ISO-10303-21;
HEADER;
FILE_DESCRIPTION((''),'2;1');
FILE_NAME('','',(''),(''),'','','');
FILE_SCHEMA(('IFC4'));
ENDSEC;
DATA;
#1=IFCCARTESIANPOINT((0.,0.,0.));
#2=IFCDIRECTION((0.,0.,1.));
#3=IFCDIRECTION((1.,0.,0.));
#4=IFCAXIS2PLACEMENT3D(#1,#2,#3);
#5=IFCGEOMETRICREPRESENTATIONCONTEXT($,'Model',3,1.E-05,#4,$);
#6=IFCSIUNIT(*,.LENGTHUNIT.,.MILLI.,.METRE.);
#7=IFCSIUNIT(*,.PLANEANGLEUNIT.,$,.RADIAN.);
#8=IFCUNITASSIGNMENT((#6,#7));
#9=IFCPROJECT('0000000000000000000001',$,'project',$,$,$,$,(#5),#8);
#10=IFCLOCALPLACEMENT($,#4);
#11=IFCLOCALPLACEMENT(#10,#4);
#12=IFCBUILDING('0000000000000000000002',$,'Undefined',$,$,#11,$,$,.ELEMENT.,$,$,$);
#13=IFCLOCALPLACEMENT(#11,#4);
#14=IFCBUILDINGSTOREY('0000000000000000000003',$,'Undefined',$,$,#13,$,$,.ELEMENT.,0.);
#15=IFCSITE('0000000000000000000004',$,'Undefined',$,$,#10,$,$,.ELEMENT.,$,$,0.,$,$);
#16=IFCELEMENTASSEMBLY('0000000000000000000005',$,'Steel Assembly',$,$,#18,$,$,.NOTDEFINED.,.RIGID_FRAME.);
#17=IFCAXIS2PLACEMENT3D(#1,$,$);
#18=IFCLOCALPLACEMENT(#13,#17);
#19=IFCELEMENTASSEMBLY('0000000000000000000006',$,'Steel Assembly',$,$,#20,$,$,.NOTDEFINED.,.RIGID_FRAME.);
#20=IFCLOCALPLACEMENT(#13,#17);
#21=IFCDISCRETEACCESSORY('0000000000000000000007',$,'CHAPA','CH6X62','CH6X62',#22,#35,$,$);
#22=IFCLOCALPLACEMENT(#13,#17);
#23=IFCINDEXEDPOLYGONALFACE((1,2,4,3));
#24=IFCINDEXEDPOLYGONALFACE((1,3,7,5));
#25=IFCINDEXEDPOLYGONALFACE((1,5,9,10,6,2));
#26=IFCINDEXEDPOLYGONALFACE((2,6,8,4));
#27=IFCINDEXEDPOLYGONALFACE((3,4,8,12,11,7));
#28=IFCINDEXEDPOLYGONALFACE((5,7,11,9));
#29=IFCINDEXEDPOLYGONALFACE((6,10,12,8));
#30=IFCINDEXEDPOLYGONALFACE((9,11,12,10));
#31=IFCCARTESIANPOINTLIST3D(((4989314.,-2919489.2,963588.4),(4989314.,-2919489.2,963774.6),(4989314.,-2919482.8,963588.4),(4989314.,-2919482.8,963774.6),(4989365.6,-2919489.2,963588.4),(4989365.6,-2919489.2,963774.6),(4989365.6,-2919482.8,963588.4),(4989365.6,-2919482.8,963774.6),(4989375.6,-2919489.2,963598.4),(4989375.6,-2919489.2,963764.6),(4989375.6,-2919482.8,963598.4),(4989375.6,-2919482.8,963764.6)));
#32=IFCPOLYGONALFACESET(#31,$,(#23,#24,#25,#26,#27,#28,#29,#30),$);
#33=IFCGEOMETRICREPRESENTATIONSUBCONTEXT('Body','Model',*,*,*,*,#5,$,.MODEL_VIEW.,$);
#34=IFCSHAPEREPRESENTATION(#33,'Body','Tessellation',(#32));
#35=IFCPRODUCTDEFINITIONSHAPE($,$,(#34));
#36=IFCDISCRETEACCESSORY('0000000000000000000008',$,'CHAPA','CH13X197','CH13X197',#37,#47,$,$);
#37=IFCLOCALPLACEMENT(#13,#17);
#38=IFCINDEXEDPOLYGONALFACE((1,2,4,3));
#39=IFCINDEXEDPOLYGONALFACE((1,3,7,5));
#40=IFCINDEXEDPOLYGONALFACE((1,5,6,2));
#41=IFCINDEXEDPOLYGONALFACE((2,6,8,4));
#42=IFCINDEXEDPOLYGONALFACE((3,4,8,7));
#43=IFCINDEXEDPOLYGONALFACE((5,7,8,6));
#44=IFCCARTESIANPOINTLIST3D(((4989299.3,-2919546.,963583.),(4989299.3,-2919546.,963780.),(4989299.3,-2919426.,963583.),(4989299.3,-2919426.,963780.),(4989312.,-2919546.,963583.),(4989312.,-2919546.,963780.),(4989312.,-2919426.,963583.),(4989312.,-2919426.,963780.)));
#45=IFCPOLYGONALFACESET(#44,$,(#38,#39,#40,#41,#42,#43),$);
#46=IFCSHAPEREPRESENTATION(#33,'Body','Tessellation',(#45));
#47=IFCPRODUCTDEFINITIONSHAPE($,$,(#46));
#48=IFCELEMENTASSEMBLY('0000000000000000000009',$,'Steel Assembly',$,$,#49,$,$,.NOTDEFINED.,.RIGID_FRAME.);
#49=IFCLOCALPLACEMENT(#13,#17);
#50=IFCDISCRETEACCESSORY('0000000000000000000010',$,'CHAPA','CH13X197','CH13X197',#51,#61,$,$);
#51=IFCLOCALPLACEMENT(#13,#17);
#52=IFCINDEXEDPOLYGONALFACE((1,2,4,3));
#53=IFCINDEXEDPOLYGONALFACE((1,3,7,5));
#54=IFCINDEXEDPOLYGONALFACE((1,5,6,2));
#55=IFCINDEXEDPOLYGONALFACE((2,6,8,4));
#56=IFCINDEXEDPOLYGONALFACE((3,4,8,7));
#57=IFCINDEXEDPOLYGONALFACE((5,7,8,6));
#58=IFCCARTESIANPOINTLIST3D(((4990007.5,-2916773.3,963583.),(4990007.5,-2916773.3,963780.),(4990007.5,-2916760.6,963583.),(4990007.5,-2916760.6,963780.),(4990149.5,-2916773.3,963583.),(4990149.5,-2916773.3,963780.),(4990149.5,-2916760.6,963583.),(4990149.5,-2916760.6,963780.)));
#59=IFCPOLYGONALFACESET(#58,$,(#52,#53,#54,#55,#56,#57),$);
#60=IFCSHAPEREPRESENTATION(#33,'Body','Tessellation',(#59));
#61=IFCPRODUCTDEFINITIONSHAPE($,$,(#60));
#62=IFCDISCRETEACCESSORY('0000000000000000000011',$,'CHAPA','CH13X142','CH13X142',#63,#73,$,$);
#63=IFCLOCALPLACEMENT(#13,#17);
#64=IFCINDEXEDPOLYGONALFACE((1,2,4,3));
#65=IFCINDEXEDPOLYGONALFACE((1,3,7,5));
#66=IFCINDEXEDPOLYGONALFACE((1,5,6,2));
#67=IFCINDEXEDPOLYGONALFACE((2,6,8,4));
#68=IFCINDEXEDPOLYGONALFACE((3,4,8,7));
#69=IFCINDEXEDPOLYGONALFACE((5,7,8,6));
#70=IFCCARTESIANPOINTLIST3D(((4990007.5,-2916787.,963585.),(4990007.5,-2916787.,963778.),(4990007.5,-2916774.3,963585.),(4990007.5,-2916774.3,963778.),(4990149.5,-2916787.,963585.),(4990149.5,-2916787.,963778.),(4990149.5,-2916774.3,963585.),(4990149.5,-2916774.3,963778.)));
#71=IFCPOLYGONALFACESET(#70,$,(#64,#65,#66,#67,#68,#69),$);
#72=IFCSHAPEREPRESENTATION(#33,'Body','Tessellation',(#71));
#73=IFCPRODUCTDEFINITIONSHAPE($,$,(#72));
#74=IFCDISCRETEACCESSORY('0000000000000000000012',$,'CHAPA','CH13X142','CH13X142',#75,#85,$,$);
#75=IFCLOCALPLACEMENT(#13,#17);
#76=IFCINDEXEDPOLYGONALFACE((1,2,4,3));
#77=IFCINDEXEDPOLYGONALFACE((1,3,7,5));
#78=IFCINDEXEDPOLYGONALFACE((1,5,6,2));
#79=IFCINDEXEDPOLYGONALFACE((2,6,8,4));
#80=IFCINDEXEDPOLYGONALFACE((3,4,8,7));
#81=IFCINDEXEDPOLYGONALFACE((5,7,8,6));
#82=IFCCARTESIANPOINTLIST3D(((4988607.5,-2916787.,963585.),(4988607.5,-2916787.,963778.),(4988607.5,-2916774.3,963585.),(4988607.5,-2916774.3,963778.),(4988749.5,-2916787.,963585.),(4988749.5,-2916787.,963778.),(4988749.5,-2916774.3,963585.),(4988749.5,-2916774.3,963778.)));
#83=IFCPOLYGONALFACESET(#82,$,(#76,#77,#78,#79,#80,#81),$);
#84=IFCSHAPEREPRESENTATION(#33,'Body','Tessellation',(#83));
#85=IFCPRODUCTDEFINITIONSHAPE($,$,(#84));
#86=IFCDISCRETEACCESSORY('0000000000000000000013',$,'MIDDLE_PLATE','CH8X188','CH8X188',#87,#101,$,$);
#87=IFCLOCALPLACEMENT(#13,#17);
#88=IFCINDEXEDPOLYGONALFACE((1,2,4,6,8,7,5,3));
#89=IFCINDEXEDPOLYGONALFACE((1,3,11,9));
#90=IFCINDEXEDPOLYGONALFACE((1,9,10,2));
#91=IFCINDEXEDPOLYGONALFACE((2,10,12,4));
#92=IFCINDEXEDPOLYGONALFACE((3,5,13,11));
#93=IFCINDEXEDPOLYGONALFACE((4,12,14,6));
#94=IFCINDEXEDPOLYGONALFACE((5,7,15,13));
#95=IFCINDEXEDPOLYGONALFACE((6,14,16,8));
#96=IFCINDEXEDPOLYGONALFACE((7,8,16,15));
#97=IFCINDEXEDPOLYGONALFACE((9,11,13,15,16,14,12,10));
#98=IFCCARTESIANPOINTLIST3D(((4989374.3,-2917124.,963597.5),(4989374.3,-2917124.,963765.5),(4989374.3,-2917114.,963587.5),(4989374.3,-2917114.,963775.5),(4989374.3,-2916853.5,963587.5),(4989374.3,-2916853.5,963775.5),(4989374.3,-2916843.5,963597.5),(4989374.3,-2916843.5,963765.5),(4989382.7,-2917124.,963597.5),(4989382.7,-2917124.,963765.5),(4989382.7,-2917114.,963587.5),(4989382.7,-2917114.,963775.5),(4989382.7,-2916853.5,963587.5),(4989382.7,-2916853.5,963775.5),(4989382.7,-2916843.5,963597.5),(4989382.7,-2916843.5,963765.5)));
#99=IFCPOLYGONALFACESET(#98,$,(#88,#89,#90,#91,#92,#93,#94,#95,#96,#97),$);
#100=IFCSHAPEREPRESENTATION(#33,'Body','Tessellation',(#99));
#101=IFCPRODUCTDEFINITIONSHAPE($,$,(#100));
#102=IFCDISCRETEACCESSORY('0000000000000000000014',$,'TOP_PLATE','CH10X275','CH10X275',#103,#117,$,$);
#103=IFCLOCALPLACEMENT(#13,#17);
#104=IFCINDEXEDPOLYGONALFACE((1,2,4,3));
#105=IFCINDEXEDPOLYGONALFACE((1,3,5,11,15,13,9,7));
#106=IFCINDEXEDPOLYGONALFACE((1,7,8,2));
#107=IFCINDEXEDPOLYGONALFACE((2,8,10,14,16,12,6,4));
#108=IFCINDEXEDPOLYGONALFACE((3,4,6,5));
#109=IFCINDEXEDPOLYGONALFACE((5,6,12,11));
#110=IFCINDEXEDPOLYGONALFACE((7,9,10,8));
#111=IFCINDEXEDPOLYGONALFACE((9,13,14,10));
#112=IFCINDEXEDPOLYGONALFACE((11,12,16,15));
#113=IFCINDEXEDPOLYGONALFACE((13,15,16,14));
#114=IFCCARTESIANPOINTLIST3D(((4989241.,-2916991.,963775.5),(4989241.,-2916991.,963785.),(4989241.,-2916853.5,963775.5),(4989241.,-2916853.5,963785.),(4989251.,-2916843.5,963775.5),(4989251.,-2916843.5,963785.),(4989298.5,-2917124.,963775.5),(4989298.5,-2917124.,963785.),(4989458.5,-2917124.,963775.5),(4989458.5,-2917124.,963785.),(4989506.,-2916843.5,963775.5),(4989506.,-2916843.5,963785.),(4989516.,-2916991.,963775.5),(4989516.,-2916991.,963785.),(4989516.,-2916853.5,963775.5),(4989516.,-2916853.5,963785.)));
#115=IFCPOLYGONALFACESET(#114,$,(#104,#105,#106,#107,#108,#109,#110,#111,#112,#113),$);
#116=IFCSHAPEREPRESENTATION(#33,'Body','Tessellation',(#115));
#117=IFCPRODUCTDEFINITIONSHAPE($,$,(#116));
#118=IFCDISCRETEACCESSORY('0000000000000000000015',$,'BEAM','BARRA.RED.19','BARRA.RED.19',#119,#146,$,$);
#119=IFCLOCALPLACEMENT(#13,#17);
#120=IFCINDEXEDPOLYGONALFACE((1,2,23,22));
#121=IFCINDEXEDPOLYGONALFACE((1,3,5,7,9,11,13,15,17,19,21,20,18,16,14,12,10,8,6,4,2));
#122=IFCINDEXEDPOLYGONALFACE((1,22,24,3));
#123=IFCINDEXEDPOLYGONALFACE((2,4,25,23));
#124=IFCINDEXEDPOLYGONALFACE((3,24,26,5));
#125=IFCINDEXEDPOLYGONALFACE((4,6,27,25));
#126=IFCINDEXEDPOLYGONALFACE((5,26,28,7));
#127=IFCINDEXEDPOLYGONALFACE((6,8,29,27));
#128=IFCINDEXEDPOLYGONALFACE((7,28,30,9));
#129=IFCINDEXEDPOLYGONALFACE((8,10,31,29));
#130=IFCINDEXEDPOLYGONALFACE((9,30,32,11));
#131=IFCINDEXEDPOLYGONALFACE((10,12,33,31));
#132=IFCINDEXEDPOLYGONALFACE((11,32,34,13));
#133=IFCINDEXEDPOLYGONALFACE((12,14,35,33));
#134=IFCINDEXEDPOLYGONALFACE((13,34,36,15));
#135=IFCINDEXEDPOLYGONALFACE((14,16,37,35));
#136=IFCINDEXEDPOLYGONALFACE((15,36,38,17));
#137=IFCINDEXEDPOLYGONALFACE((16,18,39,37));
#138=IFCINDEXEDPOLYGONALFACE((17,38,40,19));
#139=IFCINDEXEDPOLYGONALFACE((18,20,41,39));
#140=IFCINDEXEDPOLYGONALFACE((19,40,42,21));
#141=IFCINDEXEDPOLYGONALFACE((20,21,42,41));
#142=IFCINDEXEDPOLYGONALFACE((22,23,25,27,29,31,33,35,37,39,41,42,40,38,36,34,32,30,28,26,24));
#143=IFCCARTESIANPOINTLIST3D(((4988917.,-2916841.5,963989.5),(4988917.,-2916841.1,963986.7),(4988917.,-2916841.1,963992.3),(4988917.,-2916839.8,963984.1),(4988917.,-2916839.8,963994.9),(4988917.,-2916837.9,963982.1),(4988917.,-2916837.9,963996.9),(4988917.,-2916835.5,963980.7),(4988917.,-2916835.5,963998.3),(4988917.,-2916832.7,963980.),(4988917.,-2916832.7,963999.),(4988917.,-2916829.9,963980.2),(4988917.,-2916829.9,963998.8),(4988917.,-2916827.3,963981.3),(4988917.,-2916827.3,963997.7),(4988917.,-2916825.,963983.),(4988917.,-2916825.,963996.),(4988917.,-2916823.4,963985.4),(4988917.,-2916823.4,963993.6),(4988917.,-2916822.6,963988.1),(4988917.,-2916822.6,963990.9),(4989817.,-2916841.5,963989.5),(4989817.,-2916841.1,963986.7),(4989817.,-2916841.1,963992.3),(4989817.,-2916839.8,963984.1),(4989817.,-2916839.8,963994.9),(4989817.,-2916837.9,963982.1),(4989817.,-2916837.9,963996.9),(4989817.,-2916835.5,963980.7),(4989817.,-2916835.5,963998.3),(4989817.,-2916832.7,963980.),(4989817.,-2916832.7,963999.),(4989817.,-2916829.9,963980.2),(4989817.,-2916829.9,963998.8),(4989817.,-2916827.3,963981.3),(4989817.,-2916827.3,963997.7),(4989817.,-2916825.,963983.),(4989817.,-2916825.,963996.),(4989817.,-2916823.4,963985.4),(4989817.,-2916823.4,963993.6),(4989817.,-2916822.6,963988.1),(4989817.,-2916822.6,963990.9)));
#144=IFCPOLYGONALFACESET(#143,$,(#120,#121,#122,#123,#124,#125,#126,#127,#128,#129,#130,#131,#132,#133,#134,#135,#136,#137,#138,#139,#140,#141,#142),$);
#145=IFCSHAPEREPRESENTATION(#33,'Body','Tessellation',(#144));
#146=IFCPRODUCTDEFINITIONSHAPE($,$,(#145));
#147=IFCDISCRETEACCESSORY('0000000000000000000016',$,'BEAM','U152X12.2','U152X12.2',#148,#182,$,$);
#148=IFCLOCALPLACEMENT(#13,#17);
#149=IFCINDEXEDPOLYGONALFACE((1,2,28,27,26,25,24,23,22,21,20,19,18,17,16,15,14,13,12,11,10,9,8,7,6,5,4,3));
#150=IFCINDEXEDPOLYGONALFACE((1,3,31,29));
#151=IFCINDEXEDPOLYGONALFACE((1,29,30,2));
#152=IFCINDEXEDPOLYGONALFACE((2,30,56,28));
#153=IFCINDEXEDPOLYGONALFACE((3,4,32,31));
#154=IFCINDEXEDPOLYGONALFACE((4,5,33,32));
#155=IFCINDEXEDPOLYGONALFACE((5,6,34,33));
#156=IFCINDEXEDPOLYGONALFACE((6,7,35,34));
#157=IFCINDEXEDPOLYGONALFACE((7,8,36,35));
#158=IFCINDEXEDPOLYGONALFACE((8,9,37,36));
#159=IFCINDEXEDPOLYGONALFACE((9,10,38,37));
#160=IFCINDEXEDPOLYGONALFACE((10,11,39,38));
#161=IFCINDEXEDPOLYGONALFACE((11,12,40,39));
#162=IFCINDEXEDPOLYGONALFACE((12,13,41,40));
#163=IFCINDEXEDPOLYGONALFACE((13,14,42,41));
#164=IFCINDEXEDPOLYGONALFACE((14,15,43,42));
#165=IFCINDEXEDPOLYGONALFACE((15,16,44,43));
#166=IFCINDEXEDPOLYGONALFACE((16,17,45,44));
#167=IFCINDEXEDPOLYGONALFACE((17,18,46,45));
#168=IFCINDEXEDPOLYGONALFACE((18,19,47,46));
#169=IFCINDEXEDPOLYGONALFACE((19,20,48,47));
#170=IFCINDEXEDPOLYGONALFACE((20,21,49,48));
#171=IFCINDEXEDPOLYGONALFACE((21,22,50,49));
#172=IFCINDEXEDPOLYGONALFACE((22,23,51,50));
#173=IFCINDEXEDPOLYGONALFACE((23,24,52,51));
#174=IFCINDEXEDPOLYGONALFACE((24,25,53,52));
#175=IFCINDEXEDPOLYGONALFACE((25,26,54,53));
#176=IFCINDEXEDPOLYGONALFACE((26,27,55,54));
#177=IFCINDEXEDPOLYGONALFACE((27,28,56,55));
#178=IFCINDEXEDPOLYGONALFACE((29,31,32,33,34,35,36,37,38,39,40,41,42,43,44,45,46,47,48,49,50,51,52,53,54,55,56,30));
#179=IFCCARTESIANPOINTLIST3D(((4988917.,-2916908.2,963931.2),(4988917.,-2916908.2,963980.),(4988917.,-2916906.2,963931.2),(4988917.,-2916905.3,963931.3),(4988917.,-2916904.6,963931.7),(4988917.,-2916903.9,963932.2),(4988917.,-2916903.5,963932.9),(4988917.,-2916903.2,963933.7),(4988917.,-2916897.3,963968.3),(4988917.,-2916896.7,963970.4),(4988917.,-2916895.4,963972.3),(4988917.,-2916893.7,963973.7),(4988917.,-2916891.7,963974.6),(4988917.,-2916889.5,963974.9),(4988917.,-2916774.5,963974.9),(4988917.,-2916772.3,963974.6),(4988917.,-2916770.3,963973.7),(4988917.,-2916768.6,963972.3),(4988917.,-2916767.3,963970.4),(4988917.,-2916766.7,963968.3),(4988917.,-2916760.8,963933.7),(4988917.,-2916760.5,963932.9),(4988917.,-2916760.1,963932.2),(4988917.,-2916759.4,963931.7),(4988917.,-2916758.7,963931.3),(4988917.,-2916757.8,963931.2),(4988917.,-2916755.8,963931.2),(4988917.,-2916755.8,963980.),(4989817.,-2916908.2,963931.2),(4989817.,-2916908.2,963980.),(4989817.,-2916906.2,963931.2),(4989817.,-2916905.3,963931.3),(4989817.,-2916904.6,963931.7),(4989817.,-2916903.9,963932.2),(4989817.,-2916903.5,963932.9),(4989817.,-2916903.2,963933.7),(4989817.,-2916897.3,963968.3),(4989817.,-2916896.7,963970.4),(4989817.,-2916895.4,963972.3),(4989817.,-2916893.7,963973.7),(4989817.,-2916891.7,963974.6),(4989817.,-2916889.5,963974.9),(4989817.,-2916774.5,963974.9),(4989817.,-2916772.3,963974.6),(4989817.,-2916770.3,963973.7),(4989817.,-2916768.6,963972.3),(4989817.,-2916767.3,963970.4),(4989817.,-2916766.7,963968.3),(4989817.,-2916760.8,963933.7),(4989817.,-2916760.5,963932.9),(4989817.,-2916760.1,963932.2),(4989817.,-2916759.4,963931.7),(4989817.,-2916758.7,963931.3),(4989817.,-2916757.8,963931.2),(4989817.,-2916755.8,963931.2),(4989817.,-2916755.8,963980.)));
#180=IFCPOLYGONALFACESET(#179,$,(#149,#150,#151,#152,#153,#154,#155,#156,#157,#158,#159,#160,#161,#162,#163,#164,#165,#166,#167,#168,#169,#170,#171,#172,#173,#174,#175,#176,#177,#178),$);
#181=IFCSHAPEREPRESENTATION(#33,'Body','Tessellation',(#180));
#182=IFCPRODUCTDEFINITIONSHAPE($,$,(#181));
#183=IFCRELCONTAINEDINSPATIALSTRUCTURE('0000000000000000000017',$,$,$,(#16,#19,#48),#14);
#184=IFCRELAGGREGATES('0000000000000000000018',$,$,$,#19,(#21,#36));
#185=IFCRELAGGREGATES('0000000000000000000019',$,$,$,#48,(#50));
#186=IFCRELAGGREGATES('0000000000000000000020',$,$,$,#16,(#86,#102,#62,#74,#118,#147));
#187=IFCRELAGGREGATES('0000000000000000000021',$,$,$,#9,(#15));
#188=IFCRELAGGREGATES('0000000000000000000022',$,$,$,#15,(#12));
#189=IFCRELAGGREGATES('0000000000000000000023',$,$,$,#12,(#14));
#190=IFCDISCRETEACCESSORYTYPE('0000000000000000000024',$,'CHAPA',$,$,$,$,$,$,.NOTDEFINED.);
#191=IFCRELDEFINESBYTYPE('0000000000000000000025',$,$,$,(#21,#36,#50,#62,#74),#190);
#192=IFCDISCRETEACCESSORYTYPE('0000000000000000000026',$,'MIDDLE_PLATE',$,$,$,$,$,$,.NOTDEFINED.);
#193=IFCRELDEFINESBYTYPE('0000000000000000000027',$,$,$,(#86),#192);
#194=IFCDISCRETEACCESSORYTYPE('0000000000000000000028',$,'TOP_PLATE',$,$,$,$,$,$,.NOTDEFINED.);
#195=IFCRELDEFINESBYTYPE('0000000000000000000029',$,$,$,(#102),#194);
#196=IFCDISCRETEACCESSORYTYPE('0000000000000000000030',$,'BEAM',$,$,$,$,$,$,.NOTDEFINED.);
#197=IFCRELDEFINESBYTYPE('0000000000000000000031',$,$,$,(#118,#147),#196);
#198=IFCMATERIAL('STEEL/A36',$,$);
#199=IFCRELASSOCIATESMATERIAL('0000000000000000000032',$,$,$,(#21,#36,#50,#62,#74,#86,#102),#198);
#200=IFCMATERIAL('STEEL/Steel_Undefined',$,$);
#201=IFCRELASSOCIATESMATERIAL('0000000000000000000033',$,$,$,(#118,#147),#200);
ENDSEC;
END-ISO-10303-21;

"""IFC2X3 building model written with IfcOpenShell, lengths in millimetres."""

from ifc_helpers import new_model, si_unit, frame, origin_with_axes, origin_2d_with_axis, place, context, subcontext, project, spatial, polyline, circle, u_section, outline, extrude, material, type_object, element, aggregate, save


model = new_model("IFC2X3")

# Units and contexts
model_context = context("Model", 3, precision=1e-05, world=origin_with_axes())
body_context = subcontext(model_context, "Body", "Model", "MODEL_VIEW")
ifc_project = project(units=[si_unit("LENGTHUNIT", "METRE", prefix="MILLI"), si_unit("PLANEANGLEUNIT", "RADIAN")], contexts=[model_context])

# Site, building, storey
site_placement = place(None, origin_with_axes())
site = spatial("IfcSite", under=ifc_project, at=site_placement, Name="Undefined", CompositionType="ELEMENT", RefElevation=0.0)
building_placement = place(site_placement, origin_with_axes())
building = spatial("IfcBuilding", under=site, at=building_placement, Name="Undefined", CompositionType="ELEMENT")
storey_placement = place(building_placement, origin_with_axes())
storey = spatial("IfcBuildingStorey", under=building, at=storey_placement, Name="Undefined", CompositionType="ELEMENT", Elevation=0.0)

# Shared definitions
ifc_material_1 = material(Name="STEEL/A36")
discrete_accessory_type_1 = type_object("IfcDiscreteAccessoryType", Name="CHAPA")

# Element assembly
assembly_1_placement = place(storey_placement, origin_with_axes())
assembly_1 = element("IfcElementAssembly", 1, at=assembly_1_placement, inside=storey, Name="Steel Assembly", AssemblyPlace="NOTDEFINED", PredefinedType="RIGID_FRAME")

# Element assembly, discrete accessories
assembly_2_placement = place(storey_placement, origin_with_axes())
assembly_2 = element("IfcElementAssembly", 2, at=assembly_2_placement, inside=storey, Name="Steel Assembly", AssemblyPlace="NOTDEFINED", PredefinedType="RIGID_FRAME")
discrete_accessory_1_placement = place(assembly_2_placement, frame((4989375.6, -2919486.0, 963774.6), z_axis=(0.0, -1.0, 0.0), x_axis=(-1.0, 0.0, 0.0)))
discrete_accessory_1 = element("IfcDiscreteAccessory", 3, at=discrete_accessory_1_placement, type_object=discrete_accessory_type_1, material=ifc_material_1, Name="CHAPA", Description="CH6X62", ObjectType="CH6X62", context=body_context, shape_type="SweptSolid", body=[
    extrude(outline(polyline([(0.0, 10.0), (10.0, 0.0), (61.6, 0.0), (61.6, 186.2), (10.0, 186.2), (0.0, 176.2), (0.0, 10.0)])), frame((0.0, 0.0, -3.2), z_axis=(0.0, 0.0, 1.0), x_axis=(1.0, 0.0, 0.0)), (0.0, 0.0, 1.0), 6.4),
])
discrete_accessory_2_placement = place(assembly_2_placement, frame((4989305.6, -2919486.0, 963780.0), z_axis=(-1.0, 0.0, 0.0), x_axis=(0.0, 0.0, -1.0)))
discrete_accessory_2 = element("IfcDiscreteAccessory", 4, at=discrete_accessory_2_placement, type_object=discrete_accessory_type_1, material=ifc_material_1, Name="CHAPA", Description="CH13X197", ObjectType="CH13X197", context=body_context, shape_type="SweptSolid", body=[
    extrude(outline(polyline([(197.0, 60.0), (197.0, -60.0), (0.0, -60.0), (0.0, 60.0), (197.0, 60.0)])), frame((0.0, 0.0, -6.3), z_axis=(0.0, 0.0, 1.0), x_axis=(1.0, 0.0, 0.0)), (0.0, 0.0, 1.0), 12.7),
])
aggregate(assembly_2, [discrete_accessory_1, discrete_accessory_2])

# Element assembly, discrete accessory
assembly_3_placement = place(storey_placement, origin_with_axes())
assembly_3 = element("IfcElementAssembly", 5, at=assembly_3_placement, inside=storey, Name="Steel Assembly", AssemblyPlace="NOTDEFINED", PredefinedType="RIGID_FRAME")
discrete_accessory_3_placement = place(assembly_3_placement, frame((4990078.5, -2916767.0, 963780.0), z_axis=(0.0, 1.0, 0.0), x_axis=(0.0, 0.0, -1.0)))
discrete_accessory_3 = element("IfcDiscreteAccessory", 6, at=discrete_accessory_3_placement, type_object=discrete_accessory_type_1, material=ifc_material_1, Name="CHAPA", Description="CH13X197", ObjectType="CH13X197", context=body_context, shape_type="SweptSolid", body=[
    extrude(outline(polyline([(197.0, 71.0), (197.0, -71.0), (0.0, -71.0), (0.0, 71.0), (197.0, 71.0)])), frame((0.0, 0.0, -6.3), z_axis=(0.0, 0.0, 1.0), x_axis=(1.0, 0.0, 0.0)), (0.0, 0.0, 1.0), 12.7),
])
aggregate(assembly_3, [discrete_accessory_3])

# Discrete accessories
discrete_accessory_4_placement = place(assembly_1_placement, frame((4990078.5, -2916780.7, 963778.0), z_axis=(0.0, 1.0, 0.0), x_axis=(0.0, 0.0, -1.0)))
discrete_accessory_4 = element("IfcDiscreteAccessory", 7, at=discrete_accessory_4_placement, type_object=discrete_accessory_type_1, material=ifc_material_1, Name="CHAPA", Description="CH13X142", ObjectType="CH13X142", context=body_context, shape_type="SweptSolid", body=[
    extrude(outline(polyline([(193.0, 71.0), (193.0, -71.0), (0.0, -71.0), (0.0, 71.0), (193.0, 71.0)])), frame((0.0, 0.0, -6.3), z_axis=(0.0, 0.0, 1.0), x_axis=(1.0, 0.0, 0.0)), (0.0, 0.0, 1.0), 12.7),
])
discrete_accessory_5_placement = place(assembly_1_placement, frame((4988678.5, -2916780.7, 963778.0), z_axis=(0.0, 1.0, 0.0), x_axis=(0.0, 0.0, -1.0)))
discrete_accessory_5 = element("IfcDiscreteAccessory", 8, at=discrete_accessory_5_placement, type_object=discrete_accessory_type_1, material=ifc_material_1, Name="CHAPA", Description="CH13X142", ObjectType="CH13X142", context=body_context, shape_type="SweptSolid", body=[
    extrude(outline(polyline([(193.0, 71.0), (193.0, -71.0), (0.0, -71.0), (0.0, 71.0), (193.0, 71.0)])), frame((0.0, 0.0, -6.3), z_axis=(0.0, 0.0, 1.0), x_axis=(1.0, 0.0, 0.0)), (0.0, 0.0, 1.0), 12.7),
])
discrete_accessory_type_2 = type_object("IfcDiscreteAccessoryType", Name="MIDDLE_PLATE")
discrete_accessory_6_placement = place(assembly_1_placement, frame((4989378.5, -2917124.0, 963775.5), z_axis=(-1.0, 0.0, 0.0), x_axis=(0.0, 1.0, 0.0)))
discrete_accessory_6 = element("IfcDiscreteAccessory", 9, at=discrete_accessory_6_placement, type_object=discrete_accessory_type_2, material=ifc_material_1, Name="MIDDLE_PLATE", Description="CH8X188", ObjectType="CH8X188", context=body_context, shape_type="SweptSolid", body=[
    extrude(outline(polyline([(0.0, 10.0), (10.0, 0.0), (270.5, 0.0), (280.5, 10.0), (280.5, 178.0), (270.5, 188.0), (10.0, 188.0), (0.0, 178.0), (0.0, 10.0)])), frame((0.0, 0.0, -4.2), z_axis=(0.0, 0.0, 1.0), x_axis=(1.0, 0.0, 0.0)), (0.0, 0.0, 1.0), 8.4),
])
discrete_accessory_type_3 = type_object("IfcDiscreteAccessoryType", Name="TOP_PLATE")
discrete_accessory_7_placement = place(assembly_1_placement, frame((4989516.0, -2916991.0, 963780.3), z_axis=(0.0, 0.0, 1.0), x_axis=(0.0, 1.0, 0.0)))
discrete_accessory_7 = element("IfcDiscreteAccessory", 10, at=discrete_accessory_7_placement, type_object=discrete_accessory_type_3, material=ifc_material_1, Name="TOP_PLATE", Description="CH10X275", ObjectType="CH10X275", context=body_context, shape_type="SweptSolid", body=[
    extrude(outline(polyline([(0.0, 0.0), (137.5, 0.0), (147.5, 10.0), (147.5, 265.0), (137.5, 275.0), (0.0, 275.0), (-133.0, 217.5), (-133.0, 57.5), (0.0, 0.0)])), frame((0.0, 0.0, -4.8), z_axis=(0.0, 0.0, 1.0), x_axis=(1.0, 0.0, 0.0)), (0.0, 0.0, 1.0), 9.5),
])
ifc_material_2 = material(Name="STEEL/Steel_Undefined")
discrete_accessory_type_4 = type_object("IfcDiscreteAccessoryType", Name="BEAM")
discrete_accessory_8_placement = place(assembly_1_placement, frame((4989817.0, -2916832.0, 963989.5), z_axis=(0.0, 0.0, -1.0), x_axis=(-1.0, 0.0, 0.0)))
discrete_accessory_8 = element("IfcDiscreteAccessory", 11, at=discrete_accessory_8_placement, type_object=discrete_accessory_type_4, material=ifc_material_2, Name="BEAM", Description="BARRA.RED.19", ObjectType="BARRA.RED.19", context=body_context, shape_type="SweptSolid", body=[
    extrude(circle(Radius=9.5, at=origin_2d_with_axis()), frame((900.0, 0.0, 0.0), z_axis=(-1.0, 0.0, 0.0), x_axis=(0.0, -1.0, 0.0)), (0.0, 0.0, 1.0), 900.0),
])
discrete_accessory_9_placement = place(assembly_1_placement, frame((4989817.0, -2916832.0, 963955.6), z_axis=(0.0, 1.0, 0.0), x_axis=(-1.0, 0.0, 0.0)))
discrete_accessory_9 = element("IfcDiscreteAccessory", 12, at=discrete_accessory_9_placement, type_object=discrete_accessory_type_4, material=ifc_material_2, Name="BEAM", Description="U152X12.2", ObjectType="U152X12.2", context=body_context, shape_type="SweptSolid", body=[
    extrude(u_section(Depth=152.4, FlangeWidth=48.8, WebThickness=5.1, FlangeThickness=8.7, FilletRadius=8.0, EdgeRadius=3.0, FlangeSlope=0.16839, at=origin_2d_with_axis()), frame((900.0, 0.0, 0.0), z_axis=(-1.0, 0.0, 0.0), x_axis=(0.0, -1.0, 0.0)), (0.0, 0.0, 1.0), 900.0),
])
aggregate(assembly_1, [discrete_accessory_6, discrete_accessory_7, discrete_accessory_4, discrete_accessory_5, discrete_accessory_8, discrete_accessory_9])

save(model, "model.ifc")
